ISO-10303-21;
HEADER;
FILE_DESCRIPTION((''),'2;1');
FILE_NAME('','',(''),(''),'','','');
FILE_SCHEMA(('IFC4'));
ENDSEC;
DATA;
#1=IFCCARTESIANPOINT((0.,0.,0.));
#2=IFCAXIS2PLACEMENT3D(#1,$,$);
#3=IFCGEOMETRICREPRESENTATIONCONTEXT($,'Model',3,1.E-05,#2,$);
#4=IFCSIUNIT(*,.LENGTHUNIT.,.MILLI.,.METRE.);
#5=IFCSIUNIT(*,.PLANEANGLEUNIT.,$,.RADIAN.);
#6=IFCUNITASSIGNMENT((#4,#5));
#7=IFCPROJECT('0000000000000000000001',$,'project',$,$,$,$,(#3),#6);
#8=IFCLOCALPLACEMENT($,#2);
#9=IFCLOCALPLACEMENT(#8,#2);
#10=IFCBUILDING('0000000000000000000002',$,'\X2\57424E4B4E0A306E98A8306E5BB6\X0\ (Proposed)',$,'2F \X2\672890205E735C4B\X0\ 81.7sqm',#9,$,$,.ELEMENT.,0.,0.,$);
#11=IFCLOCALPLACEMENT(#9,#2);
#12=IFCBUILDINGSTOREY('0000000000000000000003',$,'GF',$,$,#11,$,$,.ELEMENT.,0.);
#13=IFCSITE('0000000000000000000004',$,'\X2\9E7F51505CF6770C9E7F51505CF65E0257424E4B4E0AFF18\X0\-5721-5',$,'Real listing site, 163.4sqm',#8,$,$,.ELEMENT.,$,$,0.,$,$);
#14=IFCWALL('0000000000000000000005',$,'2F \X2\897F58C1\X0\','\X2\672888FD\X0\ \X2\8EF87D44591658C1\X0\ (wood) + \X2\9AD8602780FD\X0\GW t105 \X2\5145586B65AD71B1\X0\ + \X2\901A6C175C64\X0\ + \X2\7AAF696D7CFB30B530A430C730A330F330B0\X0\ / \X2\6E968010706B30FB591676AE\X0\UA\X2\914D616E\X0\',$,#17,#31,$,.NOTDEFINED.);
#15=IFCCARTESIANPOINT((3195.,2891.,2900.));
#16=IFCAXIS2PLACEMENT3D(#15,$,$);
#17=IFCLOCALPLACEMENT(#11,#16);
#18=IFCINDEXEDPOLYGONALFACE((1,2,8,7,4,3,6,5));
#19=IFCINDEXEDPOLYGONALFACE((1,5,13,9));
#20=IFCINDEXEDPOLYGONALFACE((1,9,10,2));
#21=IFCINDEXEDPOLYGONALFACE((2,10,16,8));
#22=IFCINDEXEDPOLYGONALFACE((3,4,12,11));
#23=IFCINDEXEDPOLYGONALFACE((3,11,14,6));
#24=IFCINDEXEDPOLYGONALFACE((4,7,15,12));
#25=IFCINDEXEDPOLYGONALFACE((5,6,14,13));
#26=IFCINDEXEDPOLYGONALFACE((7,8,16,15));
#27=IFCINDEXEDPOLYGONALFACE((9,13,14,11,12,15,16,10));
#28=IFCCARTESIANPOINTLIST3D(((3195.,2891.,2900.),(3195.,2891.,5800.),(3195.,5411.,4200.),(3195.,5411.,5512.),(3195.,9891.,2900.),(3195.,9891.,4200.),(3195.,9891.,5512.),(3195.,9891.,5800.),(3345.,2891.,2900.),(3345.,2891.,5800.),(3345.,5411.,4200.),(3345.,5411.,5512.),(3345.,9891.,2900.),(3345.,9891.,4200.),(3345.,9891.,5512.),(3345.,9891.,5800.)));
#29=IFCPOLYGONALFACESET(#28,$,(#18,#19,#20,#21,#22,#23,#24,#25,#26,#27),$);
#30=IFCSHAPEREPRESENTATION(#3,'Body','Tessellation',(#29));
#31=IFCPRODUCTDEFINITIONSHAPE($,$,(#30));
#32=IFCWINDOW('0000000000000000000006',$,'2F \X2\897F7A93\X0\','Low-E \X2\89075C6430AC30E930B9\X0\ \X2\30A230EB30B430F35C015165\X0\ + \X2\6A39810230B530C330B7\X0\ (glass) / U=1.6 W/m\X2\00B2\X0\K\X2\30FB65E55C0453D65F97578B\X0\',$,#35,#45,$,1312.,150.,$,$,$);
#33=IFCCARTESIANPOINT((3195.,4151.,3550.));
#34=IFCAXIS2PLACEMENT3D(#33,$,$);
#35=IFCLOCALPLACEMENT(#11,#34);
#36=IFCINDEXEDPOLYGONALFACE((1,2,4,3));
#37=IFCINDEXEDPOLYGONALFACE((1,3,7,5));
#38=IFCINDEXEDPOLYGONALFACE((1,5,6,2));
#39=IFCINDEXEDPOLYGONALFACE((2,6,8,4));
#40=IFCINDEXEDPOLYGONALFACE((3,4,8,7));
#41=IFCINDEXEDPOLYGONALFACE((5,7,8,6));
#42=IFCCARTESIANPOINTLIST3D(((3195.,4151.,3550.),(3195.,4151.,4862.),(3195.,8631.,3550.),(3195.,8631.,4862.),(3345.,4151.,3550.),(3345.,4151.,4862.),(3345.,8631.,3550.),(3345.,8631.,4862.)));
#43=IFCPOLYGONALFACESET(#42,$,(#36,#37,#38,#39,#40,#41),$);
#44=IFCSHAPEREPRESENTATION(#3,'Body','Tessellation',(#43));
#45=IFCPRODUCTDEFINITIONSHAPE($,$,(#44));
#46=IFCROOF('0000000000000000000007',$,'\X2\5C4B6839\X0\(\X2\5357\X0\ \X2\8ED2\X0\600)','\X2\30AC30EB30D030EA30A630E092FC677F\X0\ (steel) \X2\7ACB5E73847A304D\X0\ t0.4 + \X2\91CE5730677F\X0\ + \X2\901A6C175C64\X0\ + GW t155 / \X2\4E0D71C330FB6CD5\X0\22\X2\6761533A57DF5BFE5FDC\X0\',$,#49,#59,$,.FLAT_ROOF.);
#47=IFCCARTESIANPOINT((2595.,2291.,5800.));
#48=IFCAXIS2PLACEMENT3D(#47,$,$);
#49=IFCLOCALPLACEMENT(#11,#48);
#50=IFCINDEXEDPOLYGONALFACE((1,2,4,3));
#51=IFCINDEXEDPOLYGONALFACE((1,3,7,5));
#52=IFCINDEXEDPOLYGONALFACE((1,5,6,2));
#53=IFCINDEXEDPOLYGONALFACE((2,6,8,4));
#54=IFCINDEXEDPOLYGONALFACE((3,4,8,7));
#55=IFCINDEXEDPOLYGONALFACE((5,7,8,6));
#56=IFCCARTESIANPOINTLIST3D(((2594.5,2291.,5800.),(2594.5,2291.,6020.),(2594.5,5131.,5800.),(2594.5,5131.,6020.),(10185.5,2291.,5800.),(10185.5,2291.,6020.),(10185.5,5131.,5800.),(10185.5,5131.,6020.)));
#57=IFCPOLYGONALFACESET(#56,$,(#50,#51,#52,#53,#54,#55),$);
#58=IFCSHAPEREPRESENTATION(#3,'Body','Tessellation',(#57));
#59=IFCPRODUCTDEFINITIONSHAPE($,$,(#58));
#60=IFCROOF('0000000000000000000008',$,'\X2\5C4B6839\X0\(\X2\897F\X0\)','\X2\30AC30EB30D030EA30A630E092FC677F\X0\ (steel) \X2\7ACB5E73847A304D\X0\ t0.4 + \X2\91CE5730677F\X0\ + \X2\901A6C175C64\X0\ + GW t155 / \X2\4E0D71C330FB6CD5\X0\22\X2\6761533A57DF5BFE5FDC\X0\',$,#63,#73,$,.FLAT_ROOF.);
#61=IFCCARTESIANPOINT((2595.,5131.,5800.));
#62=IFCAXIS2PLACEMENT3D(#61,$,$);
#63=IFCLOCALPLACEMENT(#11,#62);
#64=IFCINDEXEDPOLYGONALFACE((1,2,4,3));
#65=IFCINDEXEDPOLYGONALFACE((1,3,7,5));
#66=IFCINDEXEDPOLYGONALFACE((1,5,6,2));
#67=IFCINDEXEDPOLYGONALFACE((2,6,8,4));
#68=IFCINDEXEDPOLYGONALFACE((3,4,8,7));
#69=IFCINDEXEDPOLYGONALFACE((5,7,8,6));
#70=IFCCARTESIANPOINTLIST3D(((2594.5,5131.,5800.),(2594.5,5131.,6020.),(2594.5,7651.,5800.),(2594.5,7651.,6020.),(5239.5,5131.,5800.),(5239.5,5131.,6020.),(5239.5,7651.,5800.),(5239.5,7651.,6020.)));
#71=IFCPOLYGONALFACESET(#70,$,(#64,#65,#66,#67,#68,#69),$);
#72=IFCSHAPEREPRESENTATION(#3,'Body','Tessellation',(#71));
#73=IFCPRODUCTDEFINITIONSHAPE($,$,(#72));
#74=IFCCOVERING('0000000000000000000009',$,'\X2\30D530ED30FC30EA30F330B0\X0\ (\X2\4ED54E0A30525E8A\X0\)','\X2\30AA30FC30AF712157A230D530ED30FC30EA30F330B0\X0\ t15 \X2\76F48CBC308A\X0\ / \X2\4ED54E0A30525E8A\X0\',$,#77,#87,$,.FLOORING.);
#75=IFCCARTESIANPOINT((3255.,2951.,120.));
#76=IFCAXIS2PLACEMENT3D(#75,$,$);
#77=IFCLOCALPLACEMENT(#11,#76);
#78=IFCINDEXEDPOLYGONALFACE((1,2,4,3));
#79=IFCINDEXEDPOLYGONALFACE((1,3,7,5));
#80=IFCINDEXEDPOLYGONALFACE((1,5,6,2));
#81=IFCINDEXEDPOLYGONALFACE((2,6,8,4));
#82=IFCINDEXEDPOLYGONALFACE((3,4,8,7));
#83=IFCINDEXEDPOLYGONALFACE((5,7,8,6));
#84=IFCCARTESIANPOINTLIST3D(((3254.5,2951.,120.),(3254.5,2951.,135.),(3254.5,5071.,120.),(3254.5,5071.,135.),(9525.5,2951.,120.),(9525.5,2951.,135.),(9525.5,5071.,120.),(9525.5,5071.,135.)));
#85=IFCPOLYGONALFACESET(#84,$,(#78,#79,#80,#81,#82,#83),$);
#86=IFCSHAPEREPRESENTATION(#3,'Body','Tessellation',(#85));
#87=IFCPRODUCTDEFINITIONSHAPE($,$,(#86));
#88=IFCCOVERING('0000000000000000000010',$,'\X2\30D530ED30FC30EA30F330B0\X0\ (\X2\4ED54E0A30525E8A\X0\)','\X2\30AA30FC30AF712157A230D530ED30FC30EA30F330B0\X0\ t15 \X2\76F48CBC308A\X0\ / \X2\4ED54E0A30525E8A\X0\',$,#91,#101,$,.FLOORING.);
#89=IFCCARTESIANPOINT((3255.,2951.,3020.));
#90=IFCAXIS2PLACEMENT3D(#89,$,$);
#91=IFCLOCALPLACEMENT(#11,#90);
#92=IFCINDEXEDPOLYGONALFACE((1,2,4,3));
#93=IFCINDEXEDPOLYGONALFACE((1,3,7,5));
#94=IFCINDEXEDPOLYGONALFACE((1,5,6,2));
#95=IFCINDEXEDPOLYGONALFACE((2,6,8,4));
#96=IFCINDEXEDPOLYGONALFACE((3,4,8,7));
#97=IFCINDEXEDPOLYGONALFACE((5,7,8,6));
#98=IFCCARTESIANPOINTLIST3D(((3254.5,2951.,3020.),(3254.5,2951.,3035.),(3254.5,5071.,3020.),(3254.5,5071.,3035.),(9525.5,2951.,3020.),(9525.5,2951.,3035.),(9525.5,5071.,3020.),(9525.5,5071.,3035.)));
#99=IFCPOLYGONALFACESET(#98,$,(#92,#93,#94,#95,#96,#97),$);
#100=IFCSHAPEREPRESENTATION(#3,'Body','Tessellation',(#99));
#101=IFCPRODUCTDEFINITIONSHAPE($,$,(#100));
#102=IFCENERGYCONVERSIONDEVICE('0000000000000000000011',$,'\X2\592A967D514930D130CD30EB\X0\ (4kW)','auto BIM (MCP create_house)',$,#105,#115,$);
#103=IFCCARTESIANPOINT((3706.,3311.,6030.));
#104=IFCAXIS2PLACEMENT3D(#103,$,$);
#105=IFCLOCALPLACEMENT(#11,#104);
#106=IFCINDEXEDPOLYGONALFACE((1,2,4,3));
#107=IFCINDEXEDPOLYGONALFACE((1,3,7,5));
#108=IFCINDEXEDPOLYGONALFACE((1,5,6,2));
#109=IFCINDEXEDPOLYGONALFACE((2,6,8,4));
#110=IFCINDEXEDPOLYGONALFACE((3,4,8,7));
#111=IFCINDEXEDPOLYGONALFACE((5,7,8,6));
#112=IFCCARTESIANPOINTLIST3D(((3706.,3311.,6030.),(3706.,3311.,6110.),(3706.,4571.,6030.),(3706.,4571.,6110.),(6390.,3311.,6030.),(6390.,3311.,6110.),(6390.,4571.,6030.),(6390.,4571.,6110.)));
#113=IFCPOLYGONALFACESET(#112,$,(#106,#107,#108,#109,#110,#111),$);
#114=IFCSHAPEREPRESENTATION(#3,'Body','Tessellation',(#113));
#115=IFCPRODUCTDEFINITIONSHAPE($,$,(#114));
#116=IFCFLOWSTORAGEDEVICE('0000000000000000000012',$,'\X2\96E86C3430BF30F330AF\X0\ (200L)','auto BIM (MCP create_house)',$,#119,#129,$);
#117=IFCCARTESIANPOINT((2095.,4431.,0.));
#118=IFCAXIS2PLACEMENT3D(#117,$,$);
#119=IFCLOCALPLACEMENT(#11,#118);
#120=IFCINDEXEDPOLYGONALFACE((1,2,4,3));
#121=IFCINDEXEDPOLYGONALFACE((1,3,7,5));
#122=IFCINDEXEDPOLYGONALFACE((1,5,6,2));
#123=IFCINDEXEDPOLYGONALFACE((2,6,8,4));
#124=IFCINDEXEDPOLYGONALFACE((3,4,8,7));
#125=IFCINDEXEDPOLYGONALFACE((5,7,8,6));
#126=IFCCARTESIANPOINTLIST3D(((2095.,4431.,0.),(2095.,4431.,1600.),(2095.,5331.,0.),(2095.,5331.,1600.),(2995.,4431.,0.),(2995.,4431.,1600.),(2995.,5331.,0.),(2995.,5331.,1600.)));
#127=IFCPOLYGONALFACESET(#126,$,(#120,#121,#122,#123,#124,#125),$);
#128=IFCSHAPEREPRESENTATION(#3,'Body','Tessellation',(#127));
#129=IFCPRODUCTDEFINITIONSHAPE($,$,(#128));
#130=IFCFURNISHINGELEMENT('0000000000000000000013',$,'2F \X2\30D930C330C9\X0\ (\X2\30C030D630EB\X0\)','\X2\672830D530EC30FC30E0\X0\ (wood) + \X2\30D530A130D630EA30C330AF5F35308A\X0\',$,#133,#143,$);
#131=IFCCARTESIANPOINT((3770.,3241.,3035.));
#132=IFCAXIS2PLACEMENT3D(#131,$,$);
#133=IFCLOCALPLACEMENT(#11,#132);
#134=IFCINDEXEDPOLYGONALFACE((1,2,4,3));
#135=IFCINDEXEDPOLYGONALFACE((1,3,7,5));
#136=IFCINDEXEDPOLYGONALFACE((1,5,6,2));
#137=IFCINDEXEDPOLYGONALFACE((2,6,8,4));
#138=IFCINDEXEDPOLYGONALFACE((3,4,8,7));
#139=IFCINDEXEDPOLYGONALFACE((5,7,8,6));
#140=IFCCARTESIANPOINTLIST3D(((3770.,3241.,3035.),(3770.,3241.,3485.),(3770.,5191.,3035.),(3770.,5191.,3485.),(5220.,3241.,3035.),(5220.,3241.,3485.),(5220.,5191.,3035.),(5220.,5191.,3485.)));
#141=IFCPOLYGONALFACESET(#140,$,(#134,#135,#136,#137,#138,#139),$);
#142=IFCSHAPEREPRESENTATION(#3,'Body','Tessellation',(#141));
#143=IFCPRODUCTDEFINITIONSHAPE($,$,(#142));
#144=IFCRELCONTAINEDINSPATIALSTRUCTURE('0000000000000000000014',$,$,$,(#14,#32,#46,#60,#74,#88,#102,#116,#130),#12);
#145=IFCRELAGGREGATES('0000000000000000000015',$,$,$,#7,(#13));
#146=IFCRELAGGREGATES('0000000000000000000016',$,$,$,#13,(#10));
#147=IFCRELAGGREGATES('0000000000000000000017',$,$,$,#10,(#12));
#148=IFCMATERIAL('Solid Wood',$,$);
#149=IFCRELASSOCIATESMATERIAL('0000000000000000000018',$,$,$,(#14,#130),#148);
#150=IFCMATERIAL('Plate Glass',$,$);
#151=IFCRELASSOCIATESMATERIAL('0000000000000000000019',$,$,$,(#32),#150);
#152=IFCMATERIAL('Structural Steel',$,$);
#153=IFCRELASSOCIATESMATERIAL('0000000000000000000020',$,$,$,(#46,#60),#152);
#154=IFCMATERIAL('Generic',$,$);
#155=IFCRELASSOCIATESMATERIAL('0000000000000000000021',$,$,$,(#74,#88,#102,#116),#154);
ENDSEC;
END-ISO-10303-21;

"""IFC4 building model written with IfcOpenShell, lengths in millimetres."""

from ifc_helpers import new_model, si_unit, frame, frame_2d, origin, place, context, project, spatial, rectangle, extrude, material, element, fill, save


model = new_model("IFC4")

# Units and contexts
model_context = context("Model", 3, precision=1e-05, world=origin())
ifc_project = project(units=[si_unit("LENGTHUNIT", "METRE", prefix="MILLI"), si_unit("PLANEANGLEUNIT", "RADIAN")], contexts=[model_context])

# Site, building, storey
site_placement = place(None, origin())
site = spatial("IfcSite", under=ifc_project, at=site_placement, Name="鹿児島県鹿児島市坂之上８-5721-5", ObjectType="Real listing site, 163.4sqm", CompositionType="ELEMENT", RefElevation=0.0)
building_placement = place(site_placement, origin())
building = spatial("IfcBuilding", under=site, at=building_placement, Name="坂之上の風の家 (Proposed)", ObjectType="2F 木造平屋 81.7sqm", CompositionType="ELEMENT", ElevationOfRefHeight=0.0, ElevationOfTerrain=0.0)
storey_placement = place(building_placement, origin())
storey = spatial("IfcBuildingStorey", under=building, at=storey_placement, Name="GF", CompositionType="ELEMENT", Elevation=0.0)

# Shared definitions
ifc_material_1 = material(Name="Solid Wood")

# Shared definitions
ifc_material_2 = material(Name="Plate Glass")

# Wall, opening, window
wall_1_placement = place(storey_placement, frame((3195.0, 2891.0, 2900.0)))
wall_1 = element("IfcWall", 1, at=wall_1_placement, inside=storey, material=ifc_material_1, Name="2F 西壁", Description="木製 軸組外壁 (wood) + 高性能GW t105 充填断熱 + 通気層 + 窯業系サイディング / 準耐火・外皮UA配慮", PredefinedType="NOTDEFINED", context=model_context, shape_type="SweptSolid", body=[
    extrude(rectangle(XDim=150.0, YDim=7000.0, at=frame_2d((75.0, 3500.0))), frame((3195.0, 2891.0, 2900.0)), (0.0, 0.0, 1.0), 2900.0),
])
opening_1_placement = place(storey_placement, frame((3195.0, 4151.0, 3550.0)))
opening_1 = element("IfcOpeningElement", 2, at=opening_1_placement, cuts=wall_1, PredefinedType="NOTDEFINED", context=model_context, shape_type="SweptSolid", body=[
    extrude(rectangle(XDim=150.0, YDim=4480.0, at=frame_2d((75.0, 2240.0))), frame((3195.0, 4151.0, 3550.0)), (0.0, 0.0, 1.0), 1312.0),
])
window_1_placement = place(storey_placement, frame((3195.0, 4151.0, 3550.0)))
window_1 = element("IfcWindow", 3, at=window_1_placement, inside=storey, material=ifc_material_2, Name="2F 西窓", Description="Low-E 複層ガラス アルゴン封入 + 樹脂サッシ (glass) / U=1.6 W/m²K・日射取得型", OverallHeight=1312.0, OverallWidth=150.0, context=model_context, shape_type="SweptSolid", body=[
    extrude(rectangle(XDim=150.0, YDim=4480.0, at=frame_2d((75.0, 2240.0))), frame((3195.0, 4151.0, 3550.0)), (0.0, 0.0, 1.0), 1312.0),
])
fill(opening_1, window_1)

# Roofs
ifc_material_3 = material(Name="Structural Steel")
roof_1_placement = place(storey_placement, frame((2595.0, 2291.0, 5800.0)))
element("IfcRoof", 4, at=roof_1_placement, inside=storey, material=ifc_material_3, Name="屋根(南 軒600)", Description="ガルバリウム鋼板 (steel) 立平葺き t0.4 + 野地板 + 通気層 + GW t155 / 不燃・法22条区域対応", PredefinedType="FLAT_ROOF", context=model_context, shape_type="SweptSolid", body=[
    extrude(rectangle(XDim=7591.0, YDim=2840.0, at=frame_2d((3795.0, 1420.0))), frame((2595.0, 2291.0, 5800.0)), (0.0, 0.0, 1.0), 220.0),
])
roof_2_placement = place(storey_placement, frame((2595.0, 5131.0, 5800.0)))
element("IfcRoof", 5, at=roof_2_placement, inside=storey, material=ifc_material_3, Name="屋根(西)", Description="ガルバリウム鋼板 (steel) 立平葺き t0.4 + 野地板 + 通気層 + GW t155 / 不燃・法22条区域対応", PredefinedType="FLAT_ROOF", context=model_context, shape_type="SweptSolid", body=[
    extrude(rectangle(XDim=2645.0, YDim=2520.0, at=frame_2d((1322.0, 1260.0))), frame((2595.0, 5131.0, 5800.0)), (0.0, 0.0, 1.0), 220.0),
])

# Coverings
ifc_material_4 = material(Name="Generic")
covering_1_placement = place(storey_placement, frame((3255.0, 2951.0, 120.0)))
element("IfcCovering", 6, at=covering_1_placement, inside=storey, material=ifc_material_4, Name="フローリング (仕上げ床)", Description="オーク無垢フローリング t15 直貼り / 仕上げ床", PredefinedType="FLOORING", context=model_context, shape_type="SweptSolid", body=[
    extrude(rectangle(XDim=6271.0, YDim=2120.0, at=frame_2d((3135.0, 1060.0))), frame((3255.0, 2951.0, 120.0)), (0.0, 0.0, 1.0), 15.0),
])
covering_2_placement = place(storey_placement, frame((3255.0, 2951.0, 3020.0)))
element("IfcCovering", 7, at=covering_2_placement, inside=storey, material=ifc_material_4, Name="フローリング (仕上げ床)", Description="オーク無垢フローリング t15 直貼り / 仕上げ床", PredefinedType="FLOORING", context=model_context, shape_type="SweptSolid", body=[
    extrude(rectangle(XDim=6271.0, YDim=2120.0, at=frame_2d((3135.0, 1060.0))), frame((3255.0, 2951.0, 3020.0)), (0.0, 0.0, 1.0), 15.0),
])

# Energy conversion device
energy_conversion_device_placement = place(storey_placement, frame((3706.0, 3311.0, 6030.0)))
element("IfcEnergyConversionDevice", 8, at=energy_conversion_device_placement, inside=storey, material=ifc_material_4, Name="太陽光パネル (4kW)", Description="auto BIM (MCP create_house)", context=model_context, shape_type="SweptSolid", body=[
    extrude(rectangle(XDim=2684.0, YDim=1260.0, at=frame_2d((1342.0, 630.0))), frame((3706.0, 3311.0, 6030.0)), (0.0, 0.0, 1.0), 80.0),
])

# Flow storage device
flow_storage_device_placement = place(storey_placement, frame((2095.0, 4431.0, 0.0)))
element("IfcFlowStorageDevice", 9, at=flow_storage_device_placement, inside=storey, material=ifc_material_4, Name="雨水タンク (200L)", Description="auto BIM (MCP create_house)", context=model_context, shape_type="SweptSolid", body=[
    extrude(rectangle(XDim=900.0, YDim=900.0, at=frame_2d((450.0, 450.0))), frame((2095.0, 4431.0, 0.0)), (0.0, 0.0, 1.0), 1600.0),
])

# Furnishing element
furnishing_placement = place(storey_placement, frame((3770.0, 3241.0, 3035.0)))
element("IfcFurnishingElement", 10, at=furnishing_placement, inside=storey, material=ifc_material_1, Name="2F ベッド (ダブル)", Description="木フレーム (wood) + ファブリック張り", context=model_context, shape_type="SweptSolid", body=[
    extrude(rectangle(XDim=1450.0, YDim=1950.0, at=frame_2d((725.0, 975.0))), frame((3770.0, 3241.0, 3035.0)), (0.0, 0.0, 1.0), 450.0),
])

save(model, "model.ifc")
